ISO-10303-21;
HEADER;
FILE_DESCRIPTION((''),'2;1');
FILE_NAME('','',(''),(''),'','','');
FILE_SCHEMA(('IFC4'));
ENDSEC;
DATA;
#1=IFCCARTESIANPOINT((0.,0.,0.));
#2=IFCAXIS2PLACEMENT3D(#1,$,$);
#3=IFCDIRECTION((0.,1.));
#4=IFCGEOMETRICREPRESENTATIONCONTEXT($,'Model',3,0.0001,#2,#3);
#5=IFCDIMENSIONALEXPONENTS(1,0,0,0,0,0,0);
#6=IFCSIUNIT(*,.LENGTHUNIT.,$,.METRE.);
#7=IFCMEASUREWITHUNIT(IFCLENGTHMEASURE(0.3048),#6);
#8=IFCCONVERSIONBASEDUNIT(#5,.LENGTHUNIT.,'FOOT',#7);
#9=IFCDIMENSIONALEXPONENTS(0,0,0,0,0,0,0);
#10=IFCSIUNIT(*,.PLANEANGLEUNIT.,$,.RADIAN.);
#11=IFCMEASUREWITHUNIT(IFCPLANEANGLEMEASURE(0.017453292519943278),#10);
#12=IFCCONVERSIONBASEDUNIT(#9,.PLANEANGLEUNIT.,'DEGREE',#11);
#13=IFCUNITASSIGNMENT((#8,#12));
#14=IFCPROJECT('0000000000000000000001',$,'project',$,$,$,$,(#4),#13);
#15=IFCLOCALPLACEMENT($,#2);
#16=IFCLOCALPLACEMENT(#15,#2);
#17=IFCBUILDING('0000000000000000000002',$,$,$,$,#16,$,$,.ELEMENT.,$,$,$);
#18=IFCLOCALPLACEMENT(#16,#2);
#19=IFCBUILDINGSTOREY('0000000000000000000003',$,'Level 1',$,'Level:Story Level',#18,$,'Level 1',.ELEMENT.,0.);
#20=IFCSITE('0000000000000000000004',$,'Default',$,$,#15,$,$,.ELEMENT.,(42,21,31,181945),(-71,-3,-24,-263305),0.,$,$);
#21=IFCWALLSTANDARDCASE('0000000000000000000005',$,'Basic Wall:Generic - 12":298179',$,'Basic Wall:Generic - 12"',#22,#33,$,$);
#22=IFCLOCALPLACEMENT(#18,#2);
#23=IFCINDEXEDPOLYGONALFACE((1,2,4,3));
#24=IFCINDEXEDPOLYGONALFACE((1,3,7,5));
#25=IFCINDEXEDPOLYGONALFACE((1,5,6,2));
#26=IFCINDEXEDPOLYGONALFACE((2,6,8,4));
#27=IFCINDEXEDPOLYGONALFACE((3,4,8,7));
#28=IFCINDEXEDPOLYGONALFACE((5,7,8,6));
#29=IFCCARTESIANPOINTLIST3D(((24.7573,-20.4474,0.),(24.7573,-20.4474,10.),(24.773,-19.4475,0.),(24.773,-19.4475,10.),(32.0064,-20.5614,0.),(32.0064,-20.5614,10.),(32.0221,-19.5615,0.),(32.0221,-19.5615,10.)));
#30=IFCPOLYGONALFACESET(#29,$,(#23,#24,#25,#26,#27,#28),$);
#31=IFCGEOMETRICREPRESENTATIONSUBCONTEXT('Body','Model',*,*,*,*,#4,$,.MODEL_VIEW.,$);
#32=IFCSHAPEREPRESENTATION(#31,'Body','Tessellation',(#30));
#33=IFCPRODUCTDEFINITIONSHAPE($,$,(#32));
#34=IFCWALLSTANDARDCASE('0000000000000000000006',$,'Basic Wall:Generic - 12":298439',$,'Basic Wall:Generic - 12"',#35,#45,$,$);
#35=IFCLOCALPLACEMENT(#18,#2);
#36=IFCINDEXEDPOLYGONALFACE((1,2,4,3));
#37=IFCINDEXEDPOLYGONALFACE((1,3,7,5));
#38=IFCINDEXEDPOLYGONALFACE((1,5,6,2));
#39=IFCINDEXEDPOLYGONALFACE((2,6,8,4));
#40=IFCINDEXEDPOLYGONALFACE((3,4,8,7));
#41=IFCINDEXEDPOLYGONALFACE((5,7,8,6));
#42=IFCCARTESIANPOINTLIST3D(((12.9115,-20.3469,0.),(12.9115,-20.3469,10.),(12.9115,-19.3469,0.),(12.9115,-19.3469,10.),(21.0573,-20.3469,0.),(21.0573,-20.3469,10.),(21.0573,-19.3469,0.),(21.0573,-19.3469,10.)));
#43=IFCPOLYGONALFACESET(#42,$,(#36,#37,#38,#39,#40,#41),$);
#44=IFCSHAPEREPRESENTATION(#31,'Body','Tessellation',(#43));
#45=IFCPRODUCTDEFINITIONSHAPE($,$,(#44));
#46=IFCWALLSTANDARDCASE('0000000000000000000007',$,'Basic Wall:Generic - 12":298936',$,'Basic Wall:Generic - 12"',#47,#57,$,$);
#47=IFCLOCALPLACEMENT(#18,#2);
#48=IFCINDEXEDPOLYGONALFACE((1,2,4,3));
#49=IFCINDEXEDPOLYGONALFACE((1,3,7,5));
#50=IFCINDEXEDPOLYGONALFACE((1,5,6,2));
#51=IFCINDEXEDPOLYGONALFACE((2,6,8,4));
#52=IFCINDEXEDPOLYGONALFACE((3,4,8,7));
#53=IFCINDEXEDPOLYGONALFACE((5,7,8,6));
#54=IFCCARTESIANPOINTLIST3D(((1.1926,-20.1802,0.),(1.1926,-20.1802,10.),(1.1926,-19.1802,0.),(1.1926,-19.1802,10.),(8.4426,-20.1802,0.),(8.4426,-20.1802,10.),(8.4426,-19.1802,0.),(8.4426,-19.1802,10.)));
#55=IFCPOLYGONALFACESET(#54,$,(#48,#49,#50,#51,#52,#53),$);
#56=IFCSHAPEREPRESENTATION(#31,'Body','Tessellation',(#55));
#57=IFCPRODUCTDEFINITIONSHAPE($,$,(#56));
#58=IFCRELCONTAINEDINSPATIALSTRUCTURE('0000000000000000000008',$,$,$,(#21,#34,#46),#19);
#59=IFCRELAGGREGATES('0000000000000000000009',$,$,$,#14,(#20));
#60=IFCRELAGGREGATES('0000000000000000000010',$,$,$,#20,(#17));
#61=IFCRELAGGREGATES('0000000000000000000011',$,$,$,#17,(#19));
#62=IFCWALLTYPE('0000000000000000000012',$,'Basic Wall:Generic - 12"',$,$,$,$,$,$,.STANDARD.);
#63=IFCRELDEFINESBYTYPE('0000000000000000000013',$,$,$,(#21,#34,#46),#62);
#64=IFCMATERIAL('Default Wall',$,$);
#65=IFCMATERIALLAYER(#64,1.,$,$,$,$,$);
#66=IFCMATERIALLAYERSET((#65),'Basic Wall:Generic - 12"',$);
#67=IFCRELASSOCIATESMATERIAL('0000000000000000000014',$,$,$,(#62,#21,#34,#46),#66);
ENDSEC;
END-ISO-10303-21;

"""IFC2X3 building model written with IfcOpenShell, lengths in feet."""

from ifc_helpers import new_model, entity, si_unit, converted_unit, direction, frame, frame_2d, origin, place, context, subcontext, project, spatial, rectangle, extrude, material, layer, layer_set, layer_usage, type_object, element, save


model = new_model("IFC2X3")

# Units and contexts
model_context = context("Model", 3, precision=0.0001, world=origin(), true_north=direction((0.0, 1.0)))
body_context = subcontext(model_context, "Body", "Model", "MODEL_VIEW")
ifc_project = project(units=[converted_unit("LENGTHUNIT", "FOOT", entity("IfcLengthMeasure", 0.3048), si_unit("LENGTHUNIT", "METRE"), dimensions=[1, 0, 0, 0, 0, 0, 0]), converted_unit("PLANEANGLEUNIT", "DEGREE", entity("IfcPlaneAngleMeasure", 0.017453292519943278), si_unit("PLANEANGLEUNIT", "RADIAN"), dimensions=[0, 0, 0, 0, 0, 0, 0])], contexts=[model_context])

# Site, building, storey
site_placement = place(None, origin())
site = spatial("IfcSite", under=ifc_project, at=site_placement, Name="Default", CompositionType="ELEMENT", RefLatitude=(42, 21, 31, 181945), RefLongitude=(-71, -3, -24, -263305), RefElevation=0.0)
building_placement = place(site_placement, origin())
building = spatial("IfcBuilding", under=site, at=building_placement, CompositionType="ELEMENT")
storey_placement = place(building_placement, origin())
storey = spatial("IfcBuildingStorey", under=building, at=storey_placement, Name="Level 1", ObjectType="Level:Story Level", LongName="Level 1", CompositionType="ELEMENT", Elevation=0.0)

# Shared definitions
ifc_material_1 = material(Name="Default Wall")

# Walls
ifc_layer_1 = layer(ifc_material_1, 1.0)
ifc_layer_set_1 = layer_set([ifc_layer_1], Name="Basic Wall:Generic - 12\"")
wall_type_1 = type_object("IfcWallType", Name="Basic Wall:Generic - 12\"", PredefinedType="STANDARD", material=ifc_layer_set_1)
ifc_layer_usage_1 = layer_usage(ifc_layer_set_1, "AXIS2", "NEGATIVE", 0.5)
wall_1_placement = place(storey_placement, frame((32.0143, -20.0615, 0.0), z_axis=(0.0, 0.0, 1.0), x_axis=(-0.999876, 0.015721, 0.0)))
element("IfcWallStandardCase", 1, at=wall_1_placement, inside=storey, type_object=wall_type_1, material=ifc_layer_usage_1, Name="Basic Wall:Generic - 12\":298179", ObjectType="Basic Wall:Generic - 12\"", context=body_context, shape_type="SweptSolid", body=[
    extrude(rectangle(XDim=7.25, YDim=1.0, at=frame_2d((3.625, 0.0), x_axis=(-1.0, 0.0))), origin(), (0.0, 0.0, 1.0), 10.0),
])
ifc_layer_usage_2 = layer_usage(ifc_layer_set_1, "AXIS2", "NEGATIVE", 0.5)
wall_2_placement = place(storey_placement, frame((21.0573, -19.8469, 0.0), z_axis=(0.0, 0.0, 1.0), x_axis=(-1.0, 0.0, 0.0)))
element("IfcWallStandardCase", 2, at=wall_2_placement, inside=storey, type_object=wall_type_1, material=ifc_layer_usage_2, Name="Basic Wall:Generic - 12\":298439", ObjectType="Basic Wall:Generic - 12\"", context=body_context, shape_type="SweptSolid", body=[
    extrude(rectangle(XDim=8.1458, YDim=1.0, at=frame_2d((4.0729, 0.0), x_axis=(-1.0, 0.0))), origin(), (0.0, 0.0, 1.0), 10.0),
])
ifc_layer_usage_3 = layer_usage(ifc_layer_set_1, "AXIS2", "NEGATIVE", 0.5)
wall_3_placement = place(storey_placement, frame((1.1926, -19.6802, 0.0)))
element("IfcWallStandardCase", 3, at=wall_3_placement, inside=storey, type_object=wall_type_1, material=ifc_layer_usage_3, Name="Basic Wall:Generic - 12\":298936", ObjectType="Basic Wall:Generic - 12\"", context=body_context, shape_type="SweptSolid", body=[
    extrude(rectangle(XDim=7.25, YDim=1.0, at=frame_2d((3.625, 0.0), x_axis=(-1.0, 0.0))), origin(), (0.0, 0.0, 1.0), 10.0),
])

save(model, "model.ifc")
